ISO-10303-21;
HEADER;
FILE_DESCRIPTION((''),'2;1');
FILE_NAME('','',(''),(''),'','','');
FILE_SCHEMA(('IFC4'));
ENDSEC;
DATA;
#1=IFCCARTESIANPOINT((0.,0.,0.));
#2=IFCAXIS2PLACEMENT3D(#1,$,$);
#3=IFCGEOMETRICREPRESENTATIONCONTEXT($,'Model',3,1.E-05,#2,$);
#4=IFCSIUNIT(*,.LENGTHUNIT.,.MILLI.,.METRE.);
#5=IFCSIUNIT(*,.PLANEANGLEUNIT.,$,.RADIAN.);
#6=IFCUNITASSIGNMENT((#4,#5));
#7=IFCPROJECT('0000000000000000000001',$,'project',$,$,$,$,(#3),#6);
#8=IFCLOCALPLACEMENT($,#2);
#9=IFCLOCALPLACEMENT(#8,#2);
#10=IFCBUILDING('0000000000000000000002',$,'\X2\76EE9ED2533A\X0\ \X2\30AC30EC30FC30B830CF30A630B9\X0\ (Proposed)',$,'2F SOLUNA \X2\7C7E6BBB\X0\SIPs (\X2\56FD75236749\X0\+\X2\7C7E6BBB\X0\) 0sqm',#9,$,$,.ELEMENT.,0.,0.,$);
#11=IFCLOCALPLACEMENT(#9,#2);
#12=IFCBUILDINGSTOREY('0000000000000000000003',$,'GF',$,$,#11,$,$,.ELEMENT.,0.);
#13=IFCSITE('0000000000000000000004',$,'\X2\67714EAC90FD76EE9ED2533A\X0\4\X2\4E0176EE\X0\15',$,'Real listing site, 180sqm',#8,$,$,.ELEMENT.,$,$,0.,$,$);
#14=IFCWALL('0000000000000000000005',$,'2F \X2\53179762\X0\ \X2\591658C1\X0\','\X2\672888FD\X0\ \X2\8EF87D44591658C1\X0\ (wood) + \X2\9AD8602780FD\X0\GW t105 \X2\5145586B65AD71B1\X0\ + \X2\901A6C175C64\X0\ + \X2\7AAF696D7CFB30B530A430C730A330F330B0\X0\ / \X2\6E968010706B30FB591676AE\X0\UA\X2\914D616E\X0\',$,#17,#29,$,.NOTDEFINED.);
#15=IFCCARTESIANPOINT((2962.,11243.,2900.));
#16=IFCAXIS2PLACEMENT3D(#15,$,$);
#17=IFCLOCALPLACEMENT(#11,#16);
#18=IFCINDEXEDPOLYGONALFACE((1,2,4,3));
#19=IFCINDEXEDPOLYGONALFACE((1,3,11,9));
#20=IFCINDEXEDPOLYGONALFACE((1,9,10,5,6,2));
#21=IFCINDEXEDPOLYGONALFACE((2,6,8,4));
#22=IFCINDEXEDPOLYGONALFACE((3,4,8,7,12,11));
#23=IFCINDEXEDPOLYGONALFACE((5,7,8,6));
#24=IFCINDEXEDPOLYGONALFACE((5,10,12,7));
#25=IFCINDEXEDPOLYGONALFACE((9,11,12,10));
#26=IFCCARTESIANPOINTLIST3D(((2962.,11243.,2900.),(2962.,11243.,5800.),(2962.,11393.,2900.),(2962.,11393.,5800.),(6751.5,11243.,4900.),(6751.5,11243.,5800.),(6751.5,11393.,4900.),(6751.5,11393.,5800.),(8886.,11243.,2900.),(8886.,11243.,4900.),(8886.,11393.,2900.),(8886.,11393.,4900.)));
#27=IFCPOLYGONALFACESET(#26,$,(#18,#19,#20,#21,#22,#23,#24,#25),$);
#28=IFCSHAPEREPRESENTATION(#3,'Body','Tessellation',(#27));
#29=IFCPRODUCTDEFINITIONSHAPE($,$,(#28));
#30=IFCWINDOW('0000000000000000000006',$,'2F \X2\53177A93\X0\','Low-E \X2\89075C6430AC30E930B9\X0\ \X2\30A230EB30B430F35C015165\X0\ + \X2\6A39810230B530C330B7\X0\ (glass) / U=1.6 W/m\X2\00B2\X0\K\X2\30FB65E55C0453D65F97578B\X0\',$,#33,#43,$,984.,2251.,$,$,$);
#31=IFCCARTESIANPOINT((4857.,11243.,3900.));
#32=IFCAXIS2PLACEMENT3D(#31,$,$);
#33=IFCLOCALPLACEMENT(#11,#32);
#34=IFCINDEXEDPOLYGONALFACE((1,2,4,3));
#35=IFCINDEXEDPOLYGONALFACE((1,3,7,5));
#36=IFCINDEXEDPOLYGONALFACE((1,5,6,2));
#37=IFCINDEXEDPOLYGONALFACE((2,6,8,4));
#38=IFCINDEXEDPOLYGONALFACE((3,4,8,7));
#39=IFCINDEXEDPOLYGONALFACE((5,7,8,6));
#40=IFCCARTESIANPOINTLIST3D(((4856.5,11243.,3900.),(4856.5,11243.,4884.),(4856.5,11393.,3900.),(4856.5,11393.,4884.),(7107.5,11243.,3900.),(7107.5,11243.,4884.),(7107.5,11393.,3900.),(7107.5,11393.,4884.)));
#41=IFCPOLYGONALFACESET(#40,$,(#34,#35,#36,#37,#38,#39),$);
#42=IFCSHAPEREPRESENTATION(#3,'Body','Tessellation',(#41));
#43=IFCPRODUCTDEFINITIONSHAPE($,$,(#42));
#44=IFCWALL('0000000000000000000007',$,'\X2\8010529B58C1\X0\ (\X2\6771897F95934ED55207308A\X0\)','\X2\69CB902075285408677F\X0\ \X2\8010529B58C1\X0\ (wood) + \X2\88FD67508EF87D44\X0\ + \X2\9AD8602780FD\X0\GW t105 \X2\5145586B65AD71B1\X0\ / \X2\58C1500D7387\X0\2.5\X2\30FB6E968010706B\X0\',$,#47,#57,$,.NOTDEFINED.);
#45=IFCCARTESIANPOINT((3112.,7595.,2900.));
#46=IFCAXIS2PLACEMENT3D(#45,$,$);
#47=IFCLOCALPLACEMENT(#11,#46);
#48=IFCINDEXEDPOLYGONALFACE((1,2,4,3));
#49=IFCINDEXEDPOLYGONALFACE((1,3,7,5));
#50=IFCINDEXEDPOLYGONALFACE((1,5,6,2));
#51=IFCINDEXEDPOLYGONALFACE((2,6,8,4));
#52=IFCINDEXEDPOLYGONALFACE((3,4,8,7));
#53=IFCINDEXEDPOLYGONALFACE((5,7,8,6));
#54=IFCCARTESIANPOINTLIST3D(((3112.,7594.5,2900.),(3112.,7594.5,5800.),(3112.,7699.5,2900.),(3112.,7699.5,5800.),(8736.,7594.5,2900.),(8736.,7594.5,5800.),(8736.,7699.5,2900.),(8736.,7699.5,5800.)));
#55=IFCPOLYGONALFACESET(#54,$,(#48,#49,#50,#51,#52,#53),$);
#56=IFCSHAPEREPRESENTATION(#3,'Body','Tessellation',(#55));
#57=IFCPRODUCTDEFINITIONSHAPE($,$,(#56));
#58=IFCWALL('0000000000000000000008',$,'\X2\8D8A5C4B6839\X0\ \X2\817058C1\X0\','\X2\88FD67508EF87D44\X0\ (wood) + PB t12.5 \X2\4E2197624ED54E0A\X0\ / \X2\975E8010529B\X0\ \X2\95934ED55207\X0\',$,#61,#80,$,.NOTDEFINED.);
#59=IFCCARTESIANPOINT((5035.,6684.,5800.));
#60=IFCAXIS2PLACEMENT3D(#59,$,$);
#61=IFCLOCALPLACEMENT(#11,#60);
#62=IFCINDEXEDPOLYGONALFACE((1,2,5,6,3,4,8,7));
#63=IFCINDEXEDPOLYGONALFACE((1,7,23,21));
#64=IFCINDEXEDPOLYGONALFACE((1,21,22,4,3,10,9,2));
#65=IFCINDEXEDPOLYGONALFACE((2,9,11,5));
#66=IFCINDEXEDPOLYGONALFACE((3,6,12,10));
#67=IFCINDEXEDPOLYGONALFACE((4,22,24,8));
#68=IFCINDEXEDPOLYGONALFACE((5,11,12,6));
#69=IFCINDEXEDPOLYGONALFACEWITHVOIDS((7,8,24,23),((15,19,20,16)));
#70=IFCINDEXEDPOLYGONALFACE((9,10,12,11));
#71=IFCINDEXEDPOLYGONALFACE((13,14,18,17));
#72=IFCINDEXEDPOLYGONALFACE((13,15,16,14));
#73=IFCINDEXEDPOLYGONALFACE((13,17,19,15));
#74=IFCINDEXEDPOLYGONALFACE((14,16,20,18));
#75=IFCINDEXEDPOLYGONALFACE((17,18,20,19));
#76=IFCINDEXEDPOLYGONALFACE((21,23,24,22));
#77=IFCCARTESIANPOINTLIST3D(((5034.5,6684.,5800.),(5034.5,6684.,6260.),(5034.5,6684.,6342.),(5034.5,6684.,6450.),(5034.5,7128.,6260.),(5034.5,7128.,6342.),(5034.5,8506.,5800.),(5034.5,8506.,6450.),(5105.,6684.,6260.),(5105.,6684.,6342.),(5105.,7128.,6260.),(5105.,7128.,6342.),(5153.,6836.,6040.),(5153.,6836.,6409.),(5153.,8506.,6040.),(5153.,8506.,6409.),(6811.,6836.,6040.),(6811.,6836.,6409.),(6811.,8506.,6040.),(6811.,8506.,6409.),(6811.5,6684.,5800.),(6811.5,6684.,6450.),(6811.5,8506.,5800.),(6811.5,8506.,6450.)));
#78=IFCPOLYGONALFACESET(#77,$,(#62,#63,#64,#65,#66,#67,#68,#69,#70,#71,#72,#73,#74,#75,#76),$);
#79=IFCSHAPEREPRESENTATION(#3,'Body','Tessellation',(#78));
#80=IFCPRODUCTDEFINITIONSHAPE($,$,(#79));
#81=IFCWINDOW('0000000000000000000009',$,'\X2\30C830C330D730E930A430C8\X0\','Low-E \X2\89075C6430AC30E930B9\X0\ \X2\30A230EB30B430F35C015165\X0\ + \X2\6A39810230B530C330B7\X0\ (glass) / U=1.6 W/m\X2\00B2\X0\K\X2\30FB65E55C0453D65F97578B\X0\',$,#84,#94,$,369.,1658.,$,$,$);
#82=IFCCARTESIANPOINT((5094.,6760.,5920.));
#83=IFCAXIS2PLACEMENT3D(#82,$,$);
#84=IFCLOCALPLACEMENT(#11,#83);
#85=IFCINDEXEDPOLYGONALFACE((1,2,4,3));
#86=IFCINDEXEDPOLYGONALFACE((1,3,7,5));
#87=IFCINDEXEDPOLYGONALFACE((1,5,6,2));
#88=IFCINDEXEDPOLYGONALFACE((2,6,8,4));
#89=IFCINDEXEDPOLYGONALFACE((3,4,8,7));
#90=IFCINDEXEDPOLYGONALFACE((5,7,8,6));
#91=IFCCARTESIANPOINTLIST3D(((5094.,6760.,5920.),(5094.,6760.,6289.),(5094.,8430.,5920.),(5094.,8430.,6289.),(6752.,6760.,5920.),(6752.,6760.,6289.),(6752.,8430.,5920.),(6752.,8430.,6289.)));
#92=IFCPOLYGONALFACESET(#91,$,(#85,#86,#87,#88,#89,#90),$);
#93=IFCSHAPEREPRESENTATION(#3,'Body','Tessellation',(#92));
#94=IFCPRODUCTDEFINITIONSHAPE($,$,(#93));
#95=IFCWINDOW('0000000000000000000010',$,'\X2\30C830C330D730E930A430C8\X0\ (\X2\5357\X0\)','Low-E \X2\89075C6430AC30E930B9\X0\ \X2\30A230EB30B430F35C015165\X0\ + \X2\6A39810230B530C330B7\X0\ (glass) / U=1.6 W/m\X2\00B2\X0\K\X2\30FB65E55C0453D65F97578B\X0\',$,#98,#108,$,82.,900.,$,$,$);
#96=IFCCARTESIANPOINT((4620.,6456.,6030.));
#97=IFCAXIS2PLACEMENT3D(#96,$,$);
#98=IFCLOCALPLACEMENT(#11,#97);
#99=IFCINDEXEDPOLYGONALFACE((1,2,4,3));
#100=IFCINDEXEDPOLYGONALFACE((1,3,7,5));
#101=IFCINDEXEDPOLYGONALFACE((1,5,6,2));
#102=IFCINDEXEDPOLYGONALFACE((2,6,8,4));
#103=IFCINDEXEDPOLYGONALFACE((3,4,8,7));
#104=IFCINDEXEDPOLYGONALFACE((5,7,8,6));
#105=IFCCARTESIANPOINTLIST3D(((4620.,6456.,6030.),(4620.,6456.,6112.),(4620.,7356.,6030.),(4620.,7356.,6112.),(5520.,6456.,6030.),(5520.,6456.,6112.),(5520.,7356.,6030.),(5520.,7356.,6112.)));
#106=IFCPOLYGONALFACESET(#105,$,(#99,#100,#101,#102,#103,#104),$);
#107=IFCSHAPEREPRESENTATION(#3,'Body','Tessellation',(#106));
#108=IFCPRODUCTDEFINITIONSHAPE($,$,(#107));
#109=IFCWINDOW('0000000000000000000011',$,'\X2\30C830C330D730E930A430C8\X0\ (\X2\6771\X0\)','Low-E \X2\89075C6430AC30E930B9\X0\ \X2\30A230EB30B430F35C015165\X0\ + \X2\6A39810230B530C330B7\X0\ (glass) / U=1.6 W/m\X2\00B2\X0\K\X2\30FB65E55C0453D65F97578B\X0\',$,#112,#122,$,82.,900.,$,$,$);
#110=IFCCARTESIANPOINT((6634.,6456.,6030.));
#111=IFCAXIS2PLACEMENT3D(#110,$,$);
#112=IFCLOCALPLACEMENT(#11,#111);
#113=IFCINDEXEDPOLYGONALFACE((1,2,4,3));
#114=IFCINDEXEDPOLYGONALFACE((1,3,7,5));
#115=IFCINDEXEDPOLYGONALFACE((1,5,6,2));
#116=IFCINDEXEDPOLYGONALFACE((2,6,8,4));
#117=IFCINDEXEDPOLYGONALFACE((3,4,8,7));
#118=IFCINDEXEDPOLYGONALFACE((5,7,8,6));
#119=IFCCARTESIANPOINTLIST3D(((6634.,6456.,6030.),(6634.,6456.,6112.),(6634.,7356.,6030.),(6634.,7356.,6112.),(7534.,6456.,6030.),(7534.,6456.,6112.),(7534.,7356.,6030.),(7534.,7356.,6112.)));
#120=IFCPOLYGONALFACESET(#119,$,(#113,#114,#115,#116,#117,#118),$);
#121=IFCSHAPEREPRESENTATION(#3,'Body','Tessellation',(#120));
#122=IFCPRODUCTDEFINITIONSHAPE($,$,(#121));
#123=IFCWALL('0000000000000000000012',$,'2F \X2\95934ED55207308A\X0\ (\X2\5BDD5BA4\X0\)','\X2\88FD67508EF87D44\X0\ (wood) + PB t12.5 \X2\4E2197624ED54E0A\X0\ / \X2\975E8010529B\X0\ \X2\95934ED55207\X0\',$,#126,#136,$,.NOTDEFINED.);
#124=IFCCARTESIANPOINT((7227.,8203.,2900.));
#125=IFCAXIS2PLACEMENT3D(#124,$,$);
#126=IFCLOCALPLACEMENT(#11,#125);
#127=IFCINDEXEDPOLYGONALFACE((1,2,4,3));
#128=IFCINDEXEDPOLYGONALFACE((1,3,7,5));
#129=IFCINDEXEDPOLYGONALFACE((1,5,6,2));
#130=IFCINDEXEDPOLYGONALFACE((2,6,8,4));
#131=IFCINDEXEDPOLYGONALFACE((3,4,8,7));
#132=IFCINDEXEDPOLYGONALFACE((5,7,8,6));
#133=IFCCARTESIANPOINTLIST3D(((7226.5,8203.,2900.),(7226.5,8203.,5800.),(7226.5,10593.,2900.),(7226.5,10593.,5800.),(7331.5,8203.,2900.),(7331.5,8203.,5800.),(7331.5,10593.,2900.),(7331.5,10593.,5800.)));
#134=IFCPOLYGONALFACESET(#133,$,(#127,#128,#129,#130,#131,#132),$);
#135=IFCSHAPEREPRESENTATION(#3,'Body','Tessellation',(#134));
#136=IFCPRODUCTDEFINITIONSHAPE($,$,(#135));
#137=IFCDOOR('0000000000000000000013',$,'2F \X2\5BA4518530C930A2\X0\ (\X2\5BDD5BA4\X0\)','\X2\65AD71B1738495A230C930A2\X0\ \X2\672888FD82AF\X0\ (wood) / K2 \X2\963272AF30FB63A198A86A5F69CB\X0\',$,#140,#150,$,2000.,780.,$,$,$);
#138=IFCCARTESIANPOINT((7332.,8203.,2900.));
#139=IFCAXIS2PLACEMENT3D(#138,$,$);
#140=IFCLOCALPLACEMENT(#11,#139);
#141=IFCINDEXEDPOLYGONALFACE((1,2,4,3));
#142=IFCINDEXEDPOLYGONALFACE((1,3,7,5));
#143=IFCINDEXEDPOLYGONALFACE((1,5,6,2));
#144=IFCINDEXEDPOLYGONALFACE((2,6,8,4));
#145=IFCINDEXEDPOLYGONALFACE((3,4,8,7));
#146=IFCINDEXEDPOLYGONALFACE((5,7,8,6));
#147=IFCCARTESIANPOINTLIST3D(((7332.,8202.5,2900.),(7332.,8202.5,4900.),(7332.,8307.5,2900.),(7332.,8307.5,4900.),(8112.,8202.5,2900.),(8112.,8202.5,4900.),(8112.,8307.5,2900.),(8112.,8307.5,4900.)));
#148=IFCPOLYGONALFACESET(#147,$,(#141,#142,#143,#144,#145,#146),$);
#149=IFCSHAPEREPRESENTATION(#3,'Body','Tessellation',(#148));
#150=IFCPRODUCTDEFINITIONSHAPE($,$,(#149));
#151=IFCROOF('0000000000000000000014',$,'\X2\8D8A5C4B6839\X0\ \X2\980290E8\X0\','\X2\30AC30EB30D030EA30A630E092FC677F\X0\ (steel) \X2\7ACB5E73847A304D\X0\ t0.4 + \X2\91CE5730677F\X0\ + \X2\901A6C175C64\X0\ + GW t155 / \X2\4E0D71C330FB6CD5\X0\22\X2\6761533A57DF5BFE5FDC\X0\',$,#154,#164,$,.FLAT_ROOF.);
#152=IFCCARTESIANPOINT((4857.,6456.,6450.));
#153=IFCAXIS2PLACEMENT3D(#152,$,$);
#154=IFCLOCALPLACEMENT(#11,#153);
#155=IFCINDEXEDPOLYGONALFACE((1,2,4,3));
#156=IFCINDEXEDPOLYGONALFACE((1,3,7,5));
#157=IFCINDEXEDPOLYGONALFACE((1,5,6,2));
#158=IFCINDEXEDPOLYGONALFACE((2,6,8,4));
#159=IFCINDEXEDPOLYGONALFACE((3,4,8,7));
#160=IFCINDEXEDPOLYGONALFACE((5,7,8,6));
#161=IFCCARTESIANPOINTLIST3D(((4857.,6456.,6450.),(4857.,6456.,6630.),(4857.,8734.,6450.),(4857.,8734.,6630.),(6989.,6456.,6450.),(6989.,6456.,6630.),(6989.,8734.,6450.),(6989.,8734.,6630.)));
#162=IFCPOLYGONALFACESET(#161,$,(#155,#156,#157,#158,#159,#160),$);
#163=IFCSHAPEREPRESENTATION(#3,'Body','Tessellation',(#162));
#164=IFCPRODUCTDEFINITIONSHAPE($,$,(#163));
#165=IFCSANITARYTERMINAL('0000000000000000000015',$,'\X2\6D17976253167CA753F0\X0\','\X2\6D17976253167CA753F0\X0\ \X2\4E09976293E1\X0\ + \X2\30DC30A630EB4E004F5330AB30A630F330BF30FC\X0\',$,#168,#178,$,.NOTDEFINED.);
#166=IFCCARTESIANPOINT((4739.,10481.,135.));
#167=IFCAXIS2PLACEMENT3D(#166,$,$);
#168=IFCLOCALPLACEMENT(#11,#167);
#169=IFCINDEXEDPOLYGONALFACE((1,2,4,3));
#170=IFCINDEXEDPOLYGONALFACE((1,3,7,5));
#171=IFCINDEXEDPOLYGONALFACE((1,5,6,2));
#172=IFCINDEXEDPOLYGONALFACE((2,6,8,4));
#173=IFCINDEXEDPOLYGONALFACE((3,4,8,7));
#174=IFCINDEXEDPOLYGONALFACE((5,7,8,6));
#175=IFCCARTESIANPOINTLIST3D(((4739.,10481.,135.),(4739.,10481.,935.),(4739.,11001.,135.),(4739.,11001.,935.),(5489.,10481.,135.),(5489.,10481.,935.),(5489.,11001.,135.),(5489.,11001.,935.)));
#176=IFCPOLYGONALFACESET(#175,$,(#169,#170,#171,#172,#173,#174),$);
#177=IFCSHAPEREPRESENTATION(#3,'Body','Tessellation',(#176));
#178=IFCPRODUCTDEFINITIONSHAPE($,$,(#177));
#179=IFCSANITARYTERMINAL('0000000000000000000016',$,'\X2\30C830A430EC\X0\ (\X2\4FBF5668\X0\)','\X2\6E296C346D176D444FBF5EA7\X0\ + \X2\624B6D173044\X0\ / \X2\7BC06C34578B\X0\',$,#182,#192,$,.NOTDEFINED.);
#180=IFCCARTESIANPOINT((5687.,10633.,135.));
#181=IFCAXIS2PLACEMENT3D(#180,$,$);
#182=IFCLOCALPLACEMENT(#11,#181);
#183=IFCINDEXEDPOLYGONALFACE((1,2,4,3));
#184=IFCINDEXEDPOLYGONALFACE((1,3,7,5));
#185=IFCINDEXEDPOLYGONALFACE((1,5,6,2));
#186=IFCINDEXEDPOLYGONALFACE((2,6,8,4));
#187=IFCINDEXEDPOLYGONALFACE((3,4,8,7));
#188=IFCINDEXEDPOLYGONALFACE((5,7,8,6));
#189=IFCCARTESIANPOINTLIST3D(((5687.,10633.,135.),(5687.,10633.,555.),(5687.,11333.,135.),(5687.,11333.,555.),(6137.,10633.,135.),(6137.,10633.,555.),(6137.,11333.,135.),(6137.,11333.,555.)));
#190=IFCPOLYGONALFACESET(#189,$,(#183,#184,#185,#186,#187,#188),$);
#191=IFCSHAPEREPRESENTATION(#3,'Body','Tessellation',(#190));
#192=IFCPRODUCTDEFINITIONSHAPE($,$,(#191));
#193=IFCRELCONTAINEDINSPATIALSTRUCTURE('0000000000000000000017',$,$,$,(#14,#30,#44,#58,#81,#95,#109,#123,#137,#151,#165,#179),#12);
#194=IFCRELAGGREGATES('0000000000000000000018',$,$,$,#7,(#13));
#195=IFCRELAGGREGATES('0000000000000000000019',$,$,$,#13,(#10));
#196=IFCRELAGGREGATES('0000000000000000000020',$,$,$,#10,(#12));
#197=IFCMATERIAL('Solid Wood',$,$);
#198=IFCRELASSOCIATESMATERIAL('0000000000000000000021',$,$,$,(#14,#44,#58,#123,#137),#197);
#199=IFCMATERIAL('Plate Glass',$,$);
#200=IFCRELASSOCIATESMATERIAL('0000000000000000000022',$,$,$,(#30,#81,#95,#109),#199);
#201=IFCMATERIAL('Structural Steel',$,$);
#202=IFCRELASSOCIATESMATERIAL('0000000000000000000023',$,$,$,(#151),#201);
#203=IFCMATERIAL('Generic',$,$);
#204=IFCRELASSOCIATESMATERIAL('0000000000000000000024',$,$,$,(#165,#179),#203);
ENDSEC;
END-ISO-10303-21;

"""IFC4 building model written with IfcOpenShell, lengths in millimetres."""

from ifc_helpers import new_model, si_unit, frame, frame_2d, origin, place, context, project, spatial, rectangle, extrude, material, element, fill, save


model = new_model("IFC4")

# Units and contexts
model_context = context("Model", 3, precision=1e-05, world=origin())
ifc_project = project(units=[si_unit("LENGTHUNIT", "METRE", prefix="MILLI"), si_unit("PLANEANGLEUNIT", "RADIAN")], contexts=[model_context])

# Site, building, storey
site_placement = place(None, origin())
site = spatial("IfcSite", under=ifc_project, at=site_placement, Name="東京都目黒区4丁目15", ObjectType="Real listing site, 180sqm", CompositionType="ELEMENT", RefElevation=0.0)
building_placement = place(site_placement, origin())
building = spatial("IfcBuilding", under=site, at=building_placement, Name="目黒区 ガレージハウス (Proposed)", ObjectType="2F SOLUNA 籾殻SIPs (国産杉+籾殻) 0sqm", CompositionType="ELEMENT", ElevationOfRefHeight=0.0, ElevationOfTerrain=0.0)
storey_placement = place(building_placement, origin())
storey = spatial("IfcBuildingStorey", under=building, at=storey_placement, Name="GF", CompositionType="ELEMENT", Elevation=0.0)

# Wall, opening, window
ifc_material_1 = material(Name="Solid Wood")
wall_1_placement = place(storey_placement, frame((2962.0, 11243.0, 2900.0)))
wall_1 = element("IfcWall", 1, at=wall_1_placement, inside=storey, material=ifc_material_1, Name="2F 北面 外壁", Description="木製 軸組外壁 (wood) + 高性能GW t105 充填断熱 + 通気層 + 窯業系サイディング / 準耐火・外皮UA配慮", PredefinedType="NOTDEFINED", context=model_context, shape_type="SweptSolid", body=[
    extrude(rectangle(XDim=5924.0, YDim=150.0, at=frame_2d((2962.0, 75.0))), frame((2962.0, 11243.0, 2900.0)), (0.0, 0.0, 1.0), 2900.0),
])
opening_1_placement = place(storey_placement, frame((4857.0, 11243.0, 3900.0)))
opening_1 = element("IfcOpeningElement", 2, at=opening_1_placement, cuts=wall_1, PredefinedType="NOTDEFINED", context=model_context, shape_type="SweptSolid", body=[
    extrude(rectangle(XDim=2251.0, YDim=150.0, at=frame_2d((1125.0, 75.0))), frame((4857.0, 11243.0, 3900.0)), (0.0, 0.0, 1.0), 984.0),
])
ifc_material_2 = material(Name="Plate Glass")
window_1_placement = place(storey_placement, frame((4857.0, 11243.0, 3900.0)))
window_1 = element("IfcWindow", 3, at=window_1_placement, inside=storey, material=ifc_material_2, Name="2F 北窓", Description="Low-E 複層ガラス アルゴン封入 + 樹脂サッシ (glass) / U=1.6 W/m²K・日射取得型", OverallHeight=984.0, OverallWidth=2251.0, context=model_context, shape_type="SweptSolid", body=[
    extrude(rectangle(XDim=2251.0, YDim=150.0, at=frame_2d((1125.0, 75.0))), frame((4857.0, 11243.0, 3900.0)), (0.0, 0.0, 1.0), 984.0),
])
fill(opening_1, window_1)

# Wall
wall_2_placement = place(storey_placement, frame((3112.0, 7595.0, 2900.0)))
element("IfcWall", 4, at=wall_2_placement, inside=storey, material=ifc_material_1, Name="耐力壁 (東西間仕切り)", Description="構造用合板 耐力壁 (wood) + 製材軸組 + 高性能GW t105 充填断熱 / 壁倍率2.5・準耐火", PredefinedType="NOTDEFINED", context=model_context, shape_type="SweptSolid", body=[
    extrude(rectangle(XDim=5624.0, YDim=105.0, at=frame_2d((2812.0, 52.0))), frame((3112.0, 7595.0, 2900.0)), (0.0, 0.0, 1.0), 2900.0),
])

# Wall, openings, windows
wall_3_placement = place(storey_placement, frame((5035.0, 6684.0, 5800.0)))
wall_3 = element("IfcWall", 5, at=wall_3_placement, inside=storey, material=ifc_material_1, Name="越屋根 腰壁", Description="製材軸組 (wood) + PB t12.5 両面仕上 / 非耐力 間仕切", PredefinedType="NOTDEFINED", context=model_context, shape_type="SweptSolid", body=[
    extrude(rectangle(XDim=1777.0, YDim=1822.0, at=frame_2d((888.0, 911.0))), frame((5035.0, 6684.0, 5800.0)), (0.0, 0.0, 1.0), 650.0),
])
opening_2_placement = place(storey_placement, frame((5094.0, 6760.0, 5920.0)))
opening_2 = element("IfcOpeningElement", 6, at=opening_2_placement, cuts=wall_3, PredefinedType="NOTDEFINED", context=model_context, shape_type="SweptSolid", body=[
    extrude(rectangle(XDim=1658.0, YDim=1670.0, at=frame_2d((829.0, 835.0))), frame((5094.0, 6760.0, 5920.0)), (0.0, 0.0, 1.0), 369.0),
])
opening_3_placement = place(storey_placement, frame((4620.0, 6456.0, 6030.0)))
opening_3 = element("IfcOpeningElement", 7, at=opening_3_placement, cuts=wall_3, PredefinedType="NOTDEFINED", context=model_context, shape_type="SweptSolid", body=[
    extrude(rectangle(XDim=900.0, YDim=900.0, at=frame_2d((450.0, 450.0))), frame((4620.0, 6456.0, 6030.0)), (0.0, 0.0, 1.0), 82.0),
])
opening_4_placement = place(storey_placement, frame((6634.0, 6456.0, 6030.0)))
opening_4 = element("IfcOpeningElement", 8, at=opening_4_placement, cuts=wall_3, PredefinedType="NOTDEFINED", context=model_context, shape_type="SweptSolid", body=[
    extrude(rectangle(XDim=900.0, YDim=900.0, at=frame_2d((450.0, 450.0))), frame((6634.0, 6456.0, 6030.0)), (0.0, 0.0, 1.0), 82.0),
])
window_2_placement = place(storey_placement, frame((5094.0, 6760.0, 5920.0)))
window_2 = element("IfcWindow", 9, at=window_2_placement, inside=storey, material=ifc_material_2, Name="トップライト", Description="Low-E 複層ガラス アルゴン封入 + 樹脂サッシ (glass) / U=1.6 W/m²K・日射取得型", OverallHeight=369.0, OverallWidth=1658.0, context=model_context, shape_type="SweptSolid", body=[
    extrude(rectangle(XDim=1658.0, YDim=1670.0, at=frame_2d((829.0, 835.0))), frame((5094.0, 6760.0, 5920.0)), (0.0, 0.0, 1.0), 369.0),
])
fill(opening_2, window_2)
window_3_placement = place(storey_placement, frame((4620.0, 6456.0, 6030.0)))
window_3 = element("IfcWindow", 10, at=window_3_placement, inside=storey, material=ifc_material_2, Name="トップライト (南)", Description="Low-E 複層ガラス アルゴン封入 + 樹脂サッシ (glass) / U=1.6 W/m²K・日射取得型", OverallHeight=82.0, OverallWidth=900.0, context=model_context, shape_type="SweptSolid", body=[
    extrude(rectangle(XDim=900.0, YDim=900.0, at=frame_2d((450.0, 450.0))), frame((4620.0, 6456.0, 6030.0)), (0.0, 0.0, 1.0), 82.0),
])
fill(opening_3, window_3)
window_4_placement = place(storey_placement, frame((6634.0, 6456.0, 6030.0)))
window_4 = element("IfcWindow", 11, at=window_4_placement, inside=storey, material=ifc_material_2, Name="トップライト (東)", Description="Low-E 複層ガラス アルゴン封入 + 樹脂サッシ (glass) / U=1.6 W/m²K・日射取得型", OverallHeight=82.0, OverallWidth=900.0, context=model_context, shape_type="SweptSolid", body=[
    extrude(rectangle(XDim=900.0, YDim=900.0, at=frame_2d((450.0, 450.0))), frame((6634.0, 6456.0, 6030.0)), (0.0, 0.0, 1.0), 82.0),
])
fill(opening_4, window_4)

# Wall
wall_4_placement = place(storey_placement, frame((7227.0, 8203.0, 2900.0)))
element("IfcWall", 12, at=wall_4_placement, inside=storey, material=ifc_material_1, Name="2F 間仕切り (寝室)", Description="製材軸組 (wood) + PB t12.5 両面仕上 / 非耐力 間仕切", PredefinedType="NOTDEFINED", context=model_context, shape_type="SweptSolid", body=[
    extrude(rectangle(XDim=105.0, YDim=2390.0, at=frame_2d((52.0, 1195.0))), frame((7227.0, 8203.0, 2900.0)), (0.0, 0.0, 1.0), 2900.0),
])

# Door
door_placement = place(storey_placement, frame((7332.0, 8203.0, 2900.0)))
element("IfcDoor", 13, at=door_placement, inside=storey, material=ifc_material_1, Name="2F 室内ドア (寝室)", Description="断熱玄関ドア 木製芯 (wood) / K2 防犯・採風機構", OverallHeight=2000.0, OverallWidth=780.0, context=model_context, shape_type="SweptSolid", body=[
    extrude(rectangle(XDim=780.0, YDim=105.0, at=frame_2d((390.0, 52.0))), frame((7332.0, 8203.0, 2900.0)), (0.0, 0.0, 1.0), 2000.0),
])

# Roof
ifc_material_3 = material(Name="Structural Steel")
roof_placement = place(storey_placement, frame((4857.0, 6456.0, 6450.0)))
element("IfcRoof", 14, at=roof_placement, inside=storey, material=ifc_material_3, Name="越屋根 頂部", Description="ガルバリウム鋼板 (steel) 立平葺き t0.4 + 野地板 + 通気層 + GW t155 / 不燃・法22条区域対応", PredefinedType="FLAT_ROOF", context=model_context, shape_type="SweptSolid", body=[
    extrude(rectangle(XDim=2132.0, YDim=2278.0, at=frame_2d((1066.0, 1139.0))), frame((4857.0, 6456.0, 6450.0)), (0.0, 0.0, 1.0), 180.0),
])

# Sanitary terminals
ifc_material_4 = material(Name="Generic")
sanitary_terminal_1_placement = place(storey_placement, frame((4739.0, 10481.0, 135.0)))
element("IfcSanitaryTerminal", 15, at=sanitary_terminal_1_placement, inside=storey, material=ifc_material_4, Name="洗面化粧台", Description="洗面化粧台 三面鏡 + ボウル一体カウンター", PredefinedType="NOTDEFINED", context=model_context, shape_type="SweptSolid", body=[
    extrude(rectangle(XDim=750.0, YDim=520.0, at=frame_2d((375.0, 260.0))), frame((4739.0, 10481.0, 135.0)), (0.0, 0.0, 1.0), 800.0),
])
sanitary_terminal_2_placement = place(storey_placement, frame((5687.0, 10633.0, 135.0)))
element("IfcSanitaryTerminal", 16, at=sanitary_terminal_2_placement, inside=storey, material=ifc_material_4, Name="トイレ (便器)", Description="温水洗浄便座 + 手洗い / 節水型", PredefinedType="NOTDEFINED", context=model_context, shape_type="SweptSolid", body=[
    extrude(rectangle(XDim=450.0, YDim=700.0, at=frame_2d((225.0, 350.0))), frame((5687.0, 10633.0, 135.0)), (0.0, 0.0, 1.0), 420.0),
])

save(model, "model.ifc")
